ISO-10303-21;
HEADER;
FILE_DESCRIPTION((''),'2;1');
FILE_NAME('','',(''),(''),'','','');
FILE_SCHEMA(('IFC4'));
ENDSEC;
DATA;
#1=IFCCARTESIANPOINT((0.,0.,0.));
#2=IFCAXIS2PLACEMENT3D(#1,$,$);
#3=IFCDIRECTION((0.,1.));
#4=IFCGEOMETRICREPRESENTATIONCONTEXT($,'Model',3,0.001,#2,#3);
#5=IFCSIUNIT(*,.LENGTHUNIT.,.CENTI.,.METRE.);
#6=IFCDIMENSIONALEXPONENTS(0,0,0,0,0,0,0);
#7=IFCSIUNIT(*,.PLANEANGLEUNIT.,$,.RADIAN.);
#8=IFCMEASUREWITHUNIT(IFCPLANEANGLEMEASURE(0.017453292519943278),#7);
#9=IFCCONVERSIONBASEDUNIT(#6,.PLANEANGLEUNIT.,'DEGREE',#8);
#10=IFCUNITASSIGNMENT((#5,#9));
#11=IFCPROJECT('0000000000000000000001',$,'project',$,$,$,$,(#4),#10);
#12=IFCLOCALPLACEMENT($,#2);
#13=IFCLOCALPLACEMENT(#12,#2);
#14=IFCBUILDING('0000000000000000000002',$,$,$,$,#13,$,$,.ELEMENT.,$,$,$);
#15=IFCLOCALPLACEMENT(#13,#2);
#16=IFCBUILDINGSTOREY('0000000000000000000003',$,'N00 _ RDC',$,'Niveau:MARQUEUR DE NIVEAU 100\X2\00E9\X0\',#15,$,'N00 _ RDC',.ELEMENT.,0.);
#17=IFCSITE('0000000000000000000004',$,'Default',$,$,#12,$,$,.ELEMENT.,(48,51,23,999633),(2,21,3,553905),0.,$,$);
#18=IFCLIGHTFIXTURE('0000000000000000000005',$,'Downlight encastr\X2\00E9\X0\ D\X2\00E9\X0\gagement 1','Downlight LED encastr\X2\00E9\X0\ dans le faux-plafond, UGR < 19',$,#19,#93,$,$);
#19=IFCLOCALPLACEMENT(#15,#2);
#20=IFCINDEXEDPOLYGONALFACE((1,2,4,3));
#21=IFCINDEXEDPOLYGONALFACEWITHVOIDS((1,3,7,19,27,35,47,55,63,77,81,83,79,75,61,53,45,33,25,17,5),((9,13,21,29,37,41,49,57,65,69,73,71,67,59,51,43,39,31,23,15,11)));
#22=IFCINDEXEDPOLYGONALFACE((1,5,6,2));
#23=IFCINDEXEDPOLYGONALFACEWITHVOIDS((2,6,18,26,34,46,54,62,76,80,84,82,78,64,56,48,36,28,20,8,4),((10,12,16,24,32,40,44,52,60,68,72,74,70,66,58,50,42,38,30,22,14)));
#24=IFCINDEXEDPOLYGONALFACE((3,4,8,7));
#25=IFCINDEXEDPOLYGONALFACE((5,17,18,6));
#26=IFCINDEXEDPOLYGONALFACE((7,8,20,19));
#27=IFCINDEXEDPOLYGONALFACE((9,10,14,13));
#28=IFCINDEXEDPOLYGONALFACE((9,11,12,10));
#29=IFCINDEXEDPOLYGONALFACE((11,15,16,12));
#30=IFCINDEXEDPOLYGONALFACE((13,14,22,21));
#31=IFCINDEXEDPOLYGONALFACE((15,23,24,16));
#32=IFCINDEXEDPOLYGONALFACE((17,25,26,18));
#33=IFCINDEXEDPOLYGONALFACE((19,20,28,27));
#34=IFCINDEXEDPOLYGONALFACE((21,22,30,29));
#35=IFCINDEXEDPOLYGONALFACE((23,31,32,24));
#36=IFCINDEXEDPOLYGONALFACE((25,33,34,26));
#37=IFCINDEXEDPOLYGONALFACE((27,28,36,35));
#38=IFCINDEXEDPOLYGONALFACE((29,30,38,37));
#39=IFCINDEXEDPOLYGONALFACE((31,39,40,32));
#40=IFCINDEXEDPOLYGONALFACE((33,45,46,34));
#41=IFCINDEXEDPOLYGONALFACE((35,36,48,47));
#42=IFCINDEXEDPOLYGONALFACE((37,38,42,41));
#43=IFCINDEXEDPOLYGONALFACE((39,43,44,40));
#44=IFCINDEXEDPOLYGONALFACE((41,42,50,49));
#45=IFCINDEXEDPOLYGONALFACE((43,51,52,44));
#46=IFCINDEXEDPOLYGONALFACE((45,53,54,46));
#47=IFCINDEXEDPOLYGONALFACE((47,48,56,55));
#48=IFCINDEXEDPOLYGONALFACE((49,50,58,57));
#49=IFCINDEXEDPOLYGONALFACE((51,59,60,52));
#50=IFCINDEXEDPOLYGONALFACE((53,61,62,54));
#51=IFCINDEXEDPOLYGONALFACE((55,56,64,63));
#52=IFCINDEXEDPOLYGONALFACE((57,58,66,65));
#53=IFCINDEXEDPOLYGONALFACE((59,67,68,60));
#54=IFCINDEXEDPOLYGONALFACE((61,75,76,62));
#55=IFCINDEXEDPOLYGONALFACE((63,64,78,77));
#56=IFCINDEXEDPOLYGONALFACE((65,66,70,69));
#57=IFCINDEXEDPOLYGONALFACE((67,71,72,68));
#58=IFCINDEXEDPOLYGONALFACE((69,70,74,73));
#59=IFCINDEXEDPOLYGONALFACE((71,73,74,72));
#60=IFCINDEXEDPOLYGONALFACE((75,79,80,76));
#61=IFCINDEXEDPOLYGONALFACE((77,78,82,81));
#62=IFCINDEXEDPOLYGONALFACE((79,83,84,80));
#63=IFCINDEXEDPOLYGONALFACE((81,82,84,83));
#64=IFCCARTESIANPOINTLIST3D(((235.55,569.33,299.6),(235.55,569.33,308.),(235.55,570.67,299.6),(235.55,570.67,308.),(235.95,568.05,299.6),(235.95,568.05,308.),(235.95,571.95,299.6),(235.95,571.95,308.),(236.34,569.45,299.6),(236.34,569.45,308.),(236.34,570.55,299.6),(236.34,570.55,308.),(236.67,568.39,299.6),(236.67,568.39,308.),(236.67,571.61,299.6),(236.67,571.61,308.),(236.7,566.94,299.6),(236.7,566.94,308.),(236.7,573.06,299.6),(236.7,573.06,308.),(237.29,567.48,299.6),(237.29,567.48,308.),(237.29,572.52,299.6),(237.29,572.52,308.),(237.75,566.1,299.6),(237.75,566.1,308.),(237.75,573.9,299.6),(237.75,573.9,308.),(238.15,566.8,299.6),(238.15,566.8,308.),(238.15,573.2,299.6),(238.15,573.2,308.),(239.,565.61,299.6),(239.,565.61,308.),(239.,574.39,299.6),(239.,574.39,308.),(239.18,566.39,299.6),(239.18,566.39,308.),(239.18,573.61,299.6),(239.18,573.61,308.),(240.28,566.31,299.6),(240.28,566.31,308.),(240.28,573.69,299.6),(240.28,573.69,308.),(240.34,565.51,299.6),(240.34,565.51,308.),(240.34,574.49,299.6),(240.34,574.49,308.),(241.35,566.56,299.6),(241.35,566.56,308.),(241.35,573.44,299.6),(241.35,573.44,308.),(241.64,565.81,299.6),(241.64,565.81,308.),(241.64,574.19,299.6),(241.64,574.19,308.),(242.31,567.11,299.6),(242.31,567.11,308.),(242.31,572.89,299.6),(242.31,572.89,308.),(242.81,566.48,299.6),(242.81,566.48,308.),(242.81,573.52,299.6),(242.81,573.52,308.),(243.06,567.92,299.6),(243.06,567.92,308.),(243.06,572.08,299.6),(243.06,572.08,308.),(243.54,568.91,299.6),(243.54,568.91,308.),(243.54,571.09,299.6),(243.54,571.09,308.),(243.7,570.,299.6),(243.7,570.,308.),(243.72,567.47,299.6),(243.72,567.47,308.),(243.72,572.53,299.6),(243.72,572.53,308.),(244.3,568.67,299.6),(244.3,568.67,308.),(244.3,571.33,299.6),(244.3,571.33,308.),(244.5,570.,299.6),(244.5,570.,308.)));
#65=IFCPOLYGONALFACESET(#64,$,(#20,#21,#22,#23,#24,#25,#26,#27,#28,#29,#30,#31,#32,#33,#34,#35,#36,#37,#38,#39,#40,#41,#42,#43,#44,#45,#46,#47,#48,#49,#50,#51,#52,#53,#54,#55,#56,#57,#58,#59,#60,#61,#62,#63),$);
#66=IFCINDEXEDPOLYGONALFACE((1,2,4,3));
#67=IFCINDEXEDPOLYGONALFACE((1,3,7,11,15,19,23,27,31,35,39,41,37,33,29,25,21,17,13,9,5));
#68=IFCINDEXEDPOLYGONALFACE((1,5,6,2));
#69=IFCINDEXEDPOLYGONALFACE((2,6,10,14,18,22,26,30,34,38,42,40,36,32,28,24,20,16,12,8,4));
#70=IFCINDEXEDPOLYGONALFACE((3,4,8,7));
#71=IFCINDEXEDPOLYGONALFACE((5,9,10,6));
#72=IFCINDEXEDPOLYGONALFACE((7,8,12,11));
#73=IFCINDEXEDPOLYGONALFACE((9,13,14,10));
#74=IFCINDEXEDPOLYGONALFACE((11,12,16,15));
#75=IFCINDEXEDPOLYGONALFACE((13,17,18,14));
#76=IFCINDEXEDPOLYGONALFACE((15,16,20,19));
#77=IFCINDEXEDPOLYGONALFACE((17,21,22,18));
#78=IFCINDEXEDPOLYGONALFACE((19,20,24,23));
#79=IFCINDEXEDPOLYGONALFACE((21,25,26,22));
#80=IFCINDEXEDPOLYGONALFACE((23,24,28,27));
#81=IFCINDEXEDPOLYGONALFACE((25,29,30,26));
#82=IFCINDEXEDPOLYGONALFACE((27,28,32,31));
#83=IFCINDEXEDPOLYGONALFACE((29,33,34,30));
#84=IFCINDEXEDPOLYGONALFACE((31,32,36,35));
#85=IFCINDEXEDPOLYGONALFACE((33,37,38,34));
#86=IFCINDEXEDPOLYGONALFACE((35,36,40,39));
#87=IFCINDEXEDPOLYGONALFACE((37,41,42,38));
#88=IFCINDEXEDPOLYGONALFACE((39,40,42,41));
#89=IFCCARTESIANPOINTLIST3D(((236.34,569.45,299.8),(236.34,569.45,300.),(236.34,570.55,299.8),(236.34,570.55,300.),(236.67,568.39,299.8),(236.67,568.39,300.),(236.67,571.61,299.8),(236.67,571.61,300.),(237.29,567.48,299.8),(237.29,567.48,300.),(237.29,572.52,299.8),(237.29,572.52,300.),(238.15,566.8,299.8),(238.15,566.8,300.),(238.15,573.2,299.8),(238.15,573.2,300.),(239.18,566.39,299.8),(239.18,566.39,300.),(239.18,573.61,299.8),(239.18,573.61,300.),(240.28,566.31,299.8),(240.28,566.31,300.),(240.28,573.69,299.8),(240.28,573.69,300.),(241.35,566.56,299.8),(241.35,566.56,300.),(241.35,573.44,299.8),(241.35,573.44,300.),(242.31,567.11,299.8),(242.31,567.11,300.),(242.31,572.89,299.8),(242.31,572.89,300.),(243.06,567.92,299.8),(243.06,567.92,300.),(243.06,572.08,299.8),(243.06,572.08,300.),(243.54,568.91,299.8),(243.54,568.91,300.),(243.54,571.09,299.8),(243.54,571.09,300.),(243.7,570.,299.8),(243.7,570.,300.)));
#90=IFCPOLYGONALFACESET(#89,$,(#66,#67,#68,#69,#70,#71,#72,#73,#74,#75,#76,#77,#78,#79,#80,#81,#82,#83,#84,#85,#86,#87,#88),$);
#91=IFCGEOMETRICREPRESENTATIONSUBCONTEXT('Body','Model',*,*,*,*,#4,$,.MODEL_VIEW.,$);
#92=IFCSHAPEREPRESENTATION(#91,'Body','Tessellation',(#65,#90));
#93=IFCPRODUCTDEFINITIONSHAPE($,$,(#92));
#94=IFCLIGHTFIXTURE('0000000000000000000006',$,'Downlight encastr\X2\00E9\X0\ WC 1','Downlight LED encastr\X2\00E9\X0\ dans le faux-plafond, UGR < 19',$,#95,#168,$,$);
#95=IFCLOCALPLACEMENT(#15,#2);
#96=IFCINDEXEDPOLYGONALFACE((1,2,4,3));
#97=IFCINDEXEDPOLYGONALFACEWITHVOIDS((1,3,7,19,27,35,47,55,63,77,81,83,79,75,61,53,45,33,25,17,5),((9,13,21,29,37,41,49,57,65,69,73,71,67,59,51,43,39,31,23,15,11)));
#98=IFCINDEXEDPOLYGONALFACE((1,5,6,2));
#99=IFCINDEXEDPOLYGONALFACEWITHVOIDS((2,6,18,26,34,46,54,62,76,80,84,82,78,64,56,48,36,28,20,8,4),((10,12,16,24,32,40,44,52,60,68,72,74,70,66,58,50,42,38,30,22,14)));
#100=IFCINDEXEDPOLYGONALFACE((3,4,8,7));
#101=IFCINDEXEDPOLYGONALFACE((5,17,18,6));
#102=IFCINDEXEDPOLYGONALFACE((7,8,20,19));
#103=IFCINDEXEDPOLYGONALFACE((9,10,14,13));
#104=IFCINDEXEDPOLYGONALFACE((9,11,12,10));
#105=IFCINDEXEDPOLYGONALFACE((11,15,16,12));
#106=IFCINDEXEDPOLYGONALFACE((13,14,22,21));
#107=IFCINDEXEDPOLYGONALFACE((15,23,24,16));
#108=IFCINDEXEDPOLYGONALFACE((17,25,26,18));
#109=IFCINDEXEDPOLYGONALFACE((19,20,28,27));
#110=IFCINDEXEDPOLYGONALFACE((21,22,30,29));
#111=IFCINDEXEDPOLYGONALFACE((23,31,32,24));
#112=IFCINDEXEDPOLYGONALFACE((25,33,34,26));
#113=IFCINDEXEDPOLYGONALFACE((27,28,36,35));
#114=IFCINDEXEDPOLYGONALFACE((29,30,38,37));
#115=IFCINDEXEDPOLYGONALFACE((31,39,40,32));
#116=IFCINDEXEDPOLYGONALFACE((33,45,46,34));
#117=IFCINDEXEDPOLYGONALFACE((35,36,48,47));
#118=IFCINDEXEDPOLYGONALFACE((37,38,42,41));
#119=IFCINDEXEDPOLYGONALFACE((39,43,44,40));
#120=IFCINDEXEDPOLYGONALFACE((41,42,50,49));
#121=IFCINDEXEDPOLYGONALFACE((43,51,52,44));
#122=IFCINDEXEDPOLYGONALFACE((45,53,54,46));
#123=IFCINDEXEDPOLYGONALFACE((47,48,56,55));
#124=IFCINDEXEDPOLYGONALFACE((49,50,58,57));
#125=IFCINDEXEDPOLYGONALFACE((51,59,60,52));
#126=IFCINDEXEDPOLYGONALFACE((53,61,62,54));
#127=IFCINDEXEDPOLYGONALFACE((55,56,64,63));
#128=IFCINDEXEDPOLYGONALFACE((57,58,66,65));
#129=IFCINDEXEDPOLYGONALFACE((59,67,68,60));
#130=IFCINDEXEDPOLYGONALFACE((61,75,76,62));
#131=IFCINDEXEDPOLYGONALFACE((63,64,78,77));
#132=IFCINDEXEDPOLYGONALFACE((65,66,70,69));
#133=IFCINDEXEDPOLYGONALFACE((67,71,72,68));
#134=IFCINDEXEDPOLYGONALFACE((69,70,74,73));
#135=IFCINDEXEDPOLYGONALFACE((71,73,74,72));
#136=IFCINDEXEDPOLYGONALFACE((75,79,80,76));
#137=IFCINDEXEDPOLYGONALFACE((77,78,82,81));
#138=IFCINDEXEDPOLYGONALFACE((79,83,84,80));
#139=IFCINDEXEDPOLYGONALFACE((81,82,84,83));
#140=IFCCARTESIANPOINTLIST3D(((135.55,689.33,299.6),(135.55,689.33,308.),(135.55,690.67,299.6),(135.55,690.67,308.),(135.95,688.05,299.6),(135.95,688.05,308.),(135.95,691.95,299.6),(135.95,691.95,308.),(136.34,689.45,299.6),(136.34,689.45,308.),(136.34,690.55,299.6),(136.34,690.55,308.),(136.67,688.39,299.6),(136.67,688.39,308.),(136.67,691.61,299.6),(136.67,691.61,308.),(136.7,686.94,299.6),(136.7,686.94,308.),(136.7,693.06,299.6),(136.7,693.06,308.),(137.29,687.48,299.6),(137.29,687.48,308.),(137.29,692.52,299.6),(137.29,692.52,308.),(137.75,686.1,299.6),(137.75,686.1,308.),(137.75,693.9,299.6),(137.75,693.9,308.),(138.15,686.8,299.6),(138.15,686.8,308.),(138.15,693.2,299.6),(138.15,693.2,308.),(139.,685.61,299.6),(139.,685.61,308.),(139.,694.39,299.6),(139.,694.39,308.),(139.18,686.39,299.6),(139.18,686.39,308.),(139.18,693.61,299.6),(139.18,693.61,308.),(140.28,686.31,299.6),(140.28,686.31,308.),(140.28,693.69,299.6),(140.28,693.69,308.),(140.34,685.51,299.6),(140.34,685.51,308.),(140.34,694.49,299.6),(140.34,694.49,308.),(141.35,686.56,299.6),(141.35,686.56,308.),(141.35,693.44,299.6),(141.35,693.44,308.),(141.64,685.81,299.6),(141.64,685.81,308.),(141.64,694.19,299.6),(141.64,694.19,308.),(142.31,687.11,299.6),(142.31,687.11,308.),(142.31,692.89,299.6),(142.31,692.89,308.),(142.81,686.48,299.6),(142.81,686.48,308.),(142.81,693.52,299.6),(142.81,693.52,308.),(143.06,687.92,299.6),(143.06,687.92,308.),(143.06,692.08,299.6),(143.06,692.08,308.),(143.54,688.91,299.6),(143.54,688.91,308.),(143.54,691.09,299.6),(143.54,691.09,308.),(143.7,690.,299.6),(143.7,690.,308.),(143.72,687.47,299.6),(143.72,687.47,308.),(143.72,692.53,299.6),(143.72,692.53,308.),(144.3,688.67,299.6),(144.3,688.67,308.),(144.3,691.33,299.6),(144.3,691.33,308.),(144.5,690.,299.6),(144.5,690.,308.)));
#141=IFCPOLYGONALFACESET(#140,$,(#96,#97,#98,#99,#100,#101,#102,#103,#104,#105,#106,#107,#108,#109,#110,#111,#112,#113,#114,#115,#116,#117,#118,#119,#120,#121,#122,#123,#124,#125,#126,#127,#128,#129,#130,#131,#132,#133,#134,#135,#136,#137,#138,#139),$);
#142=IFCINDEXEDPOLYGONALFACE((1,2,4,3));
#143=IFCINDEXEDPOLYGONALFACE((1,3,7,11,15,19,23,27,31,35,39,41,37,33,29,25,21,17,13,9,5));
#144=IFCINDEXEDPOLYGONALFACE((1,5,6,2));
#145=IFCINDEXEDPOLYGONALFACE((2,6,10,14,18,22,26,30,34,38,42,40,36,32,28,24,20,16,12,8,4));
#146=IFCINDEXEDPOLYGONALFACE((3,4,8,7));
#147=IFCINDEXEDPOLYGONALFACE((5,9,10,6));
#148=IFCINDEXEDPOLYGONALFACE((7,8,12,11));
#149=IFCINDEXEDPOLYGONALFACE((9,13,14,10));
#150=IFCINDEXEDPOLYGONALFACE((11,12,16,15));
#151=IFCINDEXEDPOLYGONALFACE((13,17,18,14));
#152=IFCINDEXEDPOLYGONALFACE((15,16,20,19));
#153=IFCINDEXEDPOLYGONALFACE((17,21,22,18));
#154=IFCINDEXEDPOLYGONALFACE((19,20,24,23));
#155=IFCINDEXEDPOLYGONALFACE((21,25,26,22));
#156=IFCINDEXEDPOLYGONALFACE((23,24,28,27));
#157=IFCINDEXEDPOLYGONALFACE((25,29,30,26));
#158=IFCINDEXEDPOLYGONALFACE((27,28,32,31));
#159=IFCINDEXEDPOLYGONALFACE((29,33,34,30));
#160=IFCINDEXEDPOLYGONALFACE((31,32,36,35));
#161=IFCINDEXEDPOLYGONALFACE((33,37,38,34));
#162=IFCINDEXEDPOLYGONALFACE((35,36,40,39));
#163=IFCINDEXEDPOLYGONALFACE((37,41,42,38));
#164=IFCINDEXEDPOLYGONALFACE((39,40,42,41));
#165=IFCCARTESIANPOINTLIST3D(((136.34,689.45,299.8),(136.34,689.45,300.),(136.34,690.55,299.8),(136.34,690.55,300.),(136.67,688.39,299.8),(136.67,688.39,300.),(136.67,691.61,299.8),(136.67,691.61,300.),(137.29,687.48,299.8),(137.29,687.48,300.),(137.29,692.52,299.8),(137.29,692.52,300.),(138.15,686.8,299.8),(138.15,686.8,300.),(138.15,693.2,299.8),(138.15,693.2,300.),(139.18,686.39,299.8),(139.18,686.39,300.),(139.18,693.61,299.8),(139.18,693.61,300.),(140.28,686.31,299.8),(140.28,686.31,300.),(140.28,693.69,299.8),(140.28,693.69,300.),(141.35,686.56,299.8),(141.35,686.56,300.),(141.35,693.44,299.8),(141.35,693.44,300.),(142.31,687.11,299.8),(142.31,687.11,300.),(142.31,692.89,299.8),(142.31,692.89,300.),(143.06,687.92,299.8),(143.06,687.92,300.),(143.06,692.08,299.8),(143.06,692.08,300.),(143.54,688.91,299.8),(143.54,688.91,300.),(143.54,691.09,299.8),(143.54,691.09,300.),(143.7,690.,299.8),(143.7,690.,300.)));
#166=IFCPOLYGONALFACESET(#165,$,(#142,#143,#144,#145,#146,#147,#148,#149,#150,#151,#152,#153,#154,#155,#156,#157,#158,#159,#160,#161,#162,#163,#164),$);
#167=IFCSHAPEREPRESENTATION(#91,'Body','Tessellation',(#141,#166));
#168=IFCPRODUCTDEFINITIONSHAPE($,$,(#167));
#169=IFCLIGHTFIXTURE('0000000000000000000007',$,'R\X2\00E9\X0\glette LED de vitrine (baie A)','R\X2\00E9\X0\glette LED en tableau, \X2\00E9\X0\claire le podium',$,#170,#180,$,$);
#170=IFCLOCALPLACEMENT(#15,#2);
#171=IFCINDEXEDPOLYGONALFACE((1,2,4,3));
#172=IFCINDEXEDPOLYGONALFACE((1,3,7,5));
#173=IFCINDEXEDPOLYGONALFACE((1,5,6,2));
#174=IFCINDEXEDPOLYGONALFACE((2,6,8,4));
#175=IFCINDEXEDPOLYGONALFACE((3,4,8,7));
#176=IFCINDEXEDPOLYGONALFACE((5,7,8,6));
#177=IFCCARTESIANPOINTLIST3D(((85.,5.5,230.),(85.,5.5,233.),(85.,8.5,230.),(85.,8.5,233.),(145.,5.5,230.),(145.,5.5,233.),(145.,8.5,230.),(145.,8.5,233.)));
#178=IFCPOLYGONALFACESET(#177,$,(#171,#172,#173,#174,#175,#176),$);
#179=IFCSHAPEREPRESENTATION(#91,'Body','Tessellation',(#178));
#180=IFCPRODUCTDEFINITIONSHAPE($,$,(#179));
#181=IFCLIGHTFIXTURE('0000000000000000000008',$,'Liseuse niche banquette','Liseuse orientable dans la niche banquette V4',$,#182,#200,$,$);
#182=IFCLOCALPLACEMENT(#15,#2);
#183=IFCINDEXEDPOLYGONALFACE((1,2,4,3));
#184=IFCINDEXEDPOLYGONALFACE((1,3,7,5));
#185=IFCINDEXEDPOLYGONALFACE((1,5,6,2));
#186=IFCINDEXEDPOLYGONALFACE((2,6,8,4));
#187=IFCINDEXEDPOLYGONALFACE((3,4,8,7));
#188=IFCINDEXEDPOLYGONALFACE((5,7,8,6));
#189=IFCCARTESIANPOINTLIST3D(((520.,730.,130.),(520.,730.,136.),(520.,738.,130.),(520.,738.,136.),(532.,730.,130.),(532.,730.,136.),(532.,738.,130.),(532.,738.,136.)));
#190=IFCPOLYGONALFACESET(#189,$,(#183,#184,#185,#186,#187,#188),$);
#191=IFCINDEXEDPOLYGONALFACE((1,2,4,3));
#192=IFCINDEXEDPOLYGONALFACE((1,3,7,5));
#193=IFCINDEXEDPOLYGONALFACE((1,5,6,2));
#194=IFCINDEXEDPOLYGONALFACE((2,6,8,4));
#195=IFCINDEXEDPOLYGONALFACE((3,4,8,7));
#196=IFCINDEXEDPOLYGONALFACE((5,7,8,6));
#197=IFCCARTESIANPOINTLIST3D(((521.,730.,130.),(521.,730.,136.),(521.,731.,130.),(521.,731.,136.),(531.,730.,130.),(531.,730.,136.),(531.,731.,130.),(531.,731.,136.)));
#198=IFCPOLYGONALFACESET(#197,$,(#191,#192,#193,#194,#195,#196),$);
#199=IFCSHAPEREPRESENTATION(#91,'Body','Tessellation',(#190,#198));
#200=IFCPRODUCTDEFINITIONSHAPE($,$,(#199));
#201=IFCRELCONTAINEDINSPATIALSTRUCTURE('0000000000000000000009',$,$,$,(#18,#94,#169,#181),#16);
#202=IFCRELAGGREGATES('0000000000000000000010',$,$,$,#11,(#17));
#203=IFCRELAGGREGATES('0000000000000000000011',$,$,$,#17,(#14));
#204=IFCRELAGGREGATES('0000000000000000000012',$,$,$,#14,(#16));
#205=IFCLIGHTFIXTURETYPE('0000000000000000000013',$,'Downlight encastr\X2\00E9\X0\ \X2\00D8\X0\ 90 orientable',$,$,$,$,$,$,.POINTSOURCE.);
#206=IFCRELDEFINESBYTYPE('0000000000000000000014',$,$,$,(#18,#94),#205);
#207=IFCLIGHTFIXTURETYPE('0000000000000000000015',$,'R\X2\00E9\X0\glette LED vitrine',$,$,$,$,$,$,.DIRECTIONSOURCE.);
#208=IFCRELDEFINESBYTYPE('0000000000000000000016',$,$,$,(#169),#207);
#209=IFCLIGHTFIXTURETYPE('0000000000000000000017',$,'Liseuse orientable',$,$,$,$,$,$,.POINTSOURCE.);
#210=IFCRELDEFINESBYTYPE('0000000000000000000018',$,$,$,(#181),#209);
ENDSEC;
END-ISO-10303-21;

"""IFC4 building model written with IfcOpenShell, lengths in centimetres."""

from ifc_helpers import new_model, entity, si_unit, converted_unit, direction, frame, frame_2d, origin, origin_with_axes, place, context, subcontext, project, spatial, rectangle, circle, hollow_circle, extrude, type_object, element, save


model = new_model("IFC4")

# Units and contexts
model_context = context("Model", 3, precision=0.001, world=origin(), true_north=direction((0.0, 1.0)))
body_context = subcontext(model_context, "Body", "Model", "MODEL_VIEW")
ifc_project = project(units=[si_unit("LENGTHUNIT", "METRE", prefix="CENTI"), converted_unit("PLANEANGLEUNIT", "DEGREE", entity("IfcPlaneAngleMeasure", 0.017453292519943278), si_unit("PLANEANGLEUNIT", "RADIAN"), dimensions=[0, 0, 0, 0, 0, 0, 0])], contexts=[model_context])

# Site, building, storey
site_placement = place(None, origin())
site = spatial("IfcSite", under=ifc_project, at=site_placement, Name="Default", CompositionType="ELEMENT", RefLatitude=(48, 51, 23, 999633), RefLongitude=(2, 21, 3, 553905), RefElevation=0.0)
building_placement = place(site_placement, origin())
building = spatial("IfcBuilding", under=site, at=building_placement, CompositionType="ELEMENT")
storey_placement = place(building_placement, origin())
storey = spatial("IfcBuildingStorey", under=building, at=storey_placement, Name="N00 _ RDC", ObjectType="Niveau:MARQUEUR DE NIVEAU 100é", LongName="N00 _ RDC", CompositionType="ELEMENT", Elevation=0.0)

# Light fixtures
light_fixture_type_1 = type_object("IfcLightFixtureType", Name="Downlight encastré Ø 90 orientable", PredefinedType="POINTSOURCE")
light_fixture_1_placement = place(storey_placement, origin_with_axes())
element("IfcLightFixture", 1, at=light_fixture_1_placement, inside=storey, type_object=light_fixture_type_1, Name="Downlight encastré Dégagement 1", Description="Downlight LED encastré dans le faux-plafond, UGR < 19", context=body_context, shape_type="SweptSolid", body=[
    extrude(hollow_circle(Radius=4.5, WallThickness=0.8, at=frame_2d((240.0, 570.0))), frame((0.0, 0.0, 299.6)), (0.0, 0.0, 1.0), 8.4),
    extrude(circle(Radius=3.7, at=frame_2d((240.0, 570.0))), frame((0.0, 0.0, 299.8)), (0.0, 0.0, 1.0), 0.2),
])
light_fixture_2_placement = place(storey_placement, origin_with_axes())
element("IfcLightFixture", 2, at=light_fixture_2_placement, inside=storey, type_object=light_fixture_type_1, Name="Downlight encastré WC 1", Description="Downlight LED encastré dans le faux-plafond, UGR < 19", context=body_context, shape_type="SweptSolid", body=[
    extrude(hollow_circle(Radius=4.5, WallThickness=0.8, at=frame_2d((140.0, 690.0))), frame((0.0, 0.0, 299.6)), (0.0, 0.0, 1.0), 8.4),
    extrude(circle(Radius=3.7, at=frame_2d((140.0, 690.0))), frame((0.0, 0.0, 299.8)), (0.0, 0.0, 1.0), 0.2),
])
light_fixture_type_2 = type_object("IfcLightFixtureType", Name="Réglette LED vitrine", PredefinedType="DIRECTIONSOURCE")
light_fixture_3_placement = place(storey_placement, origin_with_axes())
element("IfcLightFixture", 3, at=light_fixture_3_placement, inside=storey, type_object=light_fixture_type_2, Name="Réglette LED de vitrine (baie A)", Description="Réglette LED en tableau, éclaire le podium", context=body_context, shape_type="SweptSolid", body=[
    extrude(rectangle(XDim=60.0, YDim=3.0, at=frame_2d((115.0, 7.0))), frame((0.0, 0.0, 230.0)), (0.0, 0.0, 1.0), 3.0),
])
light_fixture_type_3 = type_object("IfcLightFixtureType", Name="Liseuse orientable", PredefinedType="POINTSOURCE")
light_fixture_4_placement = place(storey_placement, origin_with_axes())
element("IfcLightFixture", 4, at=light_fixture_4_placement, inside=storey, type_object=light_fixture_type_3, Name="Liseuse niche banquette", Description="Liseuse orientable dans la niche banquette V4", context=body_context, shape_type="SweptSolid", body=[
    extrude(rectangle(XDim=12.0, YDim=8.0, at=frame_2d((526.0, 734.0))), frame((0.0, 0.0, 130.0)), (0.0, 0.0, 1.0), 6.0),
    extrude(rectangle(XDim=10.0, YDim=1.0, at=frame_2d((526.0, 730.5))), frame((0.0, 0.0, 130.0)), (0.0, 0.0, 1.0), 6.0),
])

save(model, "model.ifc")
